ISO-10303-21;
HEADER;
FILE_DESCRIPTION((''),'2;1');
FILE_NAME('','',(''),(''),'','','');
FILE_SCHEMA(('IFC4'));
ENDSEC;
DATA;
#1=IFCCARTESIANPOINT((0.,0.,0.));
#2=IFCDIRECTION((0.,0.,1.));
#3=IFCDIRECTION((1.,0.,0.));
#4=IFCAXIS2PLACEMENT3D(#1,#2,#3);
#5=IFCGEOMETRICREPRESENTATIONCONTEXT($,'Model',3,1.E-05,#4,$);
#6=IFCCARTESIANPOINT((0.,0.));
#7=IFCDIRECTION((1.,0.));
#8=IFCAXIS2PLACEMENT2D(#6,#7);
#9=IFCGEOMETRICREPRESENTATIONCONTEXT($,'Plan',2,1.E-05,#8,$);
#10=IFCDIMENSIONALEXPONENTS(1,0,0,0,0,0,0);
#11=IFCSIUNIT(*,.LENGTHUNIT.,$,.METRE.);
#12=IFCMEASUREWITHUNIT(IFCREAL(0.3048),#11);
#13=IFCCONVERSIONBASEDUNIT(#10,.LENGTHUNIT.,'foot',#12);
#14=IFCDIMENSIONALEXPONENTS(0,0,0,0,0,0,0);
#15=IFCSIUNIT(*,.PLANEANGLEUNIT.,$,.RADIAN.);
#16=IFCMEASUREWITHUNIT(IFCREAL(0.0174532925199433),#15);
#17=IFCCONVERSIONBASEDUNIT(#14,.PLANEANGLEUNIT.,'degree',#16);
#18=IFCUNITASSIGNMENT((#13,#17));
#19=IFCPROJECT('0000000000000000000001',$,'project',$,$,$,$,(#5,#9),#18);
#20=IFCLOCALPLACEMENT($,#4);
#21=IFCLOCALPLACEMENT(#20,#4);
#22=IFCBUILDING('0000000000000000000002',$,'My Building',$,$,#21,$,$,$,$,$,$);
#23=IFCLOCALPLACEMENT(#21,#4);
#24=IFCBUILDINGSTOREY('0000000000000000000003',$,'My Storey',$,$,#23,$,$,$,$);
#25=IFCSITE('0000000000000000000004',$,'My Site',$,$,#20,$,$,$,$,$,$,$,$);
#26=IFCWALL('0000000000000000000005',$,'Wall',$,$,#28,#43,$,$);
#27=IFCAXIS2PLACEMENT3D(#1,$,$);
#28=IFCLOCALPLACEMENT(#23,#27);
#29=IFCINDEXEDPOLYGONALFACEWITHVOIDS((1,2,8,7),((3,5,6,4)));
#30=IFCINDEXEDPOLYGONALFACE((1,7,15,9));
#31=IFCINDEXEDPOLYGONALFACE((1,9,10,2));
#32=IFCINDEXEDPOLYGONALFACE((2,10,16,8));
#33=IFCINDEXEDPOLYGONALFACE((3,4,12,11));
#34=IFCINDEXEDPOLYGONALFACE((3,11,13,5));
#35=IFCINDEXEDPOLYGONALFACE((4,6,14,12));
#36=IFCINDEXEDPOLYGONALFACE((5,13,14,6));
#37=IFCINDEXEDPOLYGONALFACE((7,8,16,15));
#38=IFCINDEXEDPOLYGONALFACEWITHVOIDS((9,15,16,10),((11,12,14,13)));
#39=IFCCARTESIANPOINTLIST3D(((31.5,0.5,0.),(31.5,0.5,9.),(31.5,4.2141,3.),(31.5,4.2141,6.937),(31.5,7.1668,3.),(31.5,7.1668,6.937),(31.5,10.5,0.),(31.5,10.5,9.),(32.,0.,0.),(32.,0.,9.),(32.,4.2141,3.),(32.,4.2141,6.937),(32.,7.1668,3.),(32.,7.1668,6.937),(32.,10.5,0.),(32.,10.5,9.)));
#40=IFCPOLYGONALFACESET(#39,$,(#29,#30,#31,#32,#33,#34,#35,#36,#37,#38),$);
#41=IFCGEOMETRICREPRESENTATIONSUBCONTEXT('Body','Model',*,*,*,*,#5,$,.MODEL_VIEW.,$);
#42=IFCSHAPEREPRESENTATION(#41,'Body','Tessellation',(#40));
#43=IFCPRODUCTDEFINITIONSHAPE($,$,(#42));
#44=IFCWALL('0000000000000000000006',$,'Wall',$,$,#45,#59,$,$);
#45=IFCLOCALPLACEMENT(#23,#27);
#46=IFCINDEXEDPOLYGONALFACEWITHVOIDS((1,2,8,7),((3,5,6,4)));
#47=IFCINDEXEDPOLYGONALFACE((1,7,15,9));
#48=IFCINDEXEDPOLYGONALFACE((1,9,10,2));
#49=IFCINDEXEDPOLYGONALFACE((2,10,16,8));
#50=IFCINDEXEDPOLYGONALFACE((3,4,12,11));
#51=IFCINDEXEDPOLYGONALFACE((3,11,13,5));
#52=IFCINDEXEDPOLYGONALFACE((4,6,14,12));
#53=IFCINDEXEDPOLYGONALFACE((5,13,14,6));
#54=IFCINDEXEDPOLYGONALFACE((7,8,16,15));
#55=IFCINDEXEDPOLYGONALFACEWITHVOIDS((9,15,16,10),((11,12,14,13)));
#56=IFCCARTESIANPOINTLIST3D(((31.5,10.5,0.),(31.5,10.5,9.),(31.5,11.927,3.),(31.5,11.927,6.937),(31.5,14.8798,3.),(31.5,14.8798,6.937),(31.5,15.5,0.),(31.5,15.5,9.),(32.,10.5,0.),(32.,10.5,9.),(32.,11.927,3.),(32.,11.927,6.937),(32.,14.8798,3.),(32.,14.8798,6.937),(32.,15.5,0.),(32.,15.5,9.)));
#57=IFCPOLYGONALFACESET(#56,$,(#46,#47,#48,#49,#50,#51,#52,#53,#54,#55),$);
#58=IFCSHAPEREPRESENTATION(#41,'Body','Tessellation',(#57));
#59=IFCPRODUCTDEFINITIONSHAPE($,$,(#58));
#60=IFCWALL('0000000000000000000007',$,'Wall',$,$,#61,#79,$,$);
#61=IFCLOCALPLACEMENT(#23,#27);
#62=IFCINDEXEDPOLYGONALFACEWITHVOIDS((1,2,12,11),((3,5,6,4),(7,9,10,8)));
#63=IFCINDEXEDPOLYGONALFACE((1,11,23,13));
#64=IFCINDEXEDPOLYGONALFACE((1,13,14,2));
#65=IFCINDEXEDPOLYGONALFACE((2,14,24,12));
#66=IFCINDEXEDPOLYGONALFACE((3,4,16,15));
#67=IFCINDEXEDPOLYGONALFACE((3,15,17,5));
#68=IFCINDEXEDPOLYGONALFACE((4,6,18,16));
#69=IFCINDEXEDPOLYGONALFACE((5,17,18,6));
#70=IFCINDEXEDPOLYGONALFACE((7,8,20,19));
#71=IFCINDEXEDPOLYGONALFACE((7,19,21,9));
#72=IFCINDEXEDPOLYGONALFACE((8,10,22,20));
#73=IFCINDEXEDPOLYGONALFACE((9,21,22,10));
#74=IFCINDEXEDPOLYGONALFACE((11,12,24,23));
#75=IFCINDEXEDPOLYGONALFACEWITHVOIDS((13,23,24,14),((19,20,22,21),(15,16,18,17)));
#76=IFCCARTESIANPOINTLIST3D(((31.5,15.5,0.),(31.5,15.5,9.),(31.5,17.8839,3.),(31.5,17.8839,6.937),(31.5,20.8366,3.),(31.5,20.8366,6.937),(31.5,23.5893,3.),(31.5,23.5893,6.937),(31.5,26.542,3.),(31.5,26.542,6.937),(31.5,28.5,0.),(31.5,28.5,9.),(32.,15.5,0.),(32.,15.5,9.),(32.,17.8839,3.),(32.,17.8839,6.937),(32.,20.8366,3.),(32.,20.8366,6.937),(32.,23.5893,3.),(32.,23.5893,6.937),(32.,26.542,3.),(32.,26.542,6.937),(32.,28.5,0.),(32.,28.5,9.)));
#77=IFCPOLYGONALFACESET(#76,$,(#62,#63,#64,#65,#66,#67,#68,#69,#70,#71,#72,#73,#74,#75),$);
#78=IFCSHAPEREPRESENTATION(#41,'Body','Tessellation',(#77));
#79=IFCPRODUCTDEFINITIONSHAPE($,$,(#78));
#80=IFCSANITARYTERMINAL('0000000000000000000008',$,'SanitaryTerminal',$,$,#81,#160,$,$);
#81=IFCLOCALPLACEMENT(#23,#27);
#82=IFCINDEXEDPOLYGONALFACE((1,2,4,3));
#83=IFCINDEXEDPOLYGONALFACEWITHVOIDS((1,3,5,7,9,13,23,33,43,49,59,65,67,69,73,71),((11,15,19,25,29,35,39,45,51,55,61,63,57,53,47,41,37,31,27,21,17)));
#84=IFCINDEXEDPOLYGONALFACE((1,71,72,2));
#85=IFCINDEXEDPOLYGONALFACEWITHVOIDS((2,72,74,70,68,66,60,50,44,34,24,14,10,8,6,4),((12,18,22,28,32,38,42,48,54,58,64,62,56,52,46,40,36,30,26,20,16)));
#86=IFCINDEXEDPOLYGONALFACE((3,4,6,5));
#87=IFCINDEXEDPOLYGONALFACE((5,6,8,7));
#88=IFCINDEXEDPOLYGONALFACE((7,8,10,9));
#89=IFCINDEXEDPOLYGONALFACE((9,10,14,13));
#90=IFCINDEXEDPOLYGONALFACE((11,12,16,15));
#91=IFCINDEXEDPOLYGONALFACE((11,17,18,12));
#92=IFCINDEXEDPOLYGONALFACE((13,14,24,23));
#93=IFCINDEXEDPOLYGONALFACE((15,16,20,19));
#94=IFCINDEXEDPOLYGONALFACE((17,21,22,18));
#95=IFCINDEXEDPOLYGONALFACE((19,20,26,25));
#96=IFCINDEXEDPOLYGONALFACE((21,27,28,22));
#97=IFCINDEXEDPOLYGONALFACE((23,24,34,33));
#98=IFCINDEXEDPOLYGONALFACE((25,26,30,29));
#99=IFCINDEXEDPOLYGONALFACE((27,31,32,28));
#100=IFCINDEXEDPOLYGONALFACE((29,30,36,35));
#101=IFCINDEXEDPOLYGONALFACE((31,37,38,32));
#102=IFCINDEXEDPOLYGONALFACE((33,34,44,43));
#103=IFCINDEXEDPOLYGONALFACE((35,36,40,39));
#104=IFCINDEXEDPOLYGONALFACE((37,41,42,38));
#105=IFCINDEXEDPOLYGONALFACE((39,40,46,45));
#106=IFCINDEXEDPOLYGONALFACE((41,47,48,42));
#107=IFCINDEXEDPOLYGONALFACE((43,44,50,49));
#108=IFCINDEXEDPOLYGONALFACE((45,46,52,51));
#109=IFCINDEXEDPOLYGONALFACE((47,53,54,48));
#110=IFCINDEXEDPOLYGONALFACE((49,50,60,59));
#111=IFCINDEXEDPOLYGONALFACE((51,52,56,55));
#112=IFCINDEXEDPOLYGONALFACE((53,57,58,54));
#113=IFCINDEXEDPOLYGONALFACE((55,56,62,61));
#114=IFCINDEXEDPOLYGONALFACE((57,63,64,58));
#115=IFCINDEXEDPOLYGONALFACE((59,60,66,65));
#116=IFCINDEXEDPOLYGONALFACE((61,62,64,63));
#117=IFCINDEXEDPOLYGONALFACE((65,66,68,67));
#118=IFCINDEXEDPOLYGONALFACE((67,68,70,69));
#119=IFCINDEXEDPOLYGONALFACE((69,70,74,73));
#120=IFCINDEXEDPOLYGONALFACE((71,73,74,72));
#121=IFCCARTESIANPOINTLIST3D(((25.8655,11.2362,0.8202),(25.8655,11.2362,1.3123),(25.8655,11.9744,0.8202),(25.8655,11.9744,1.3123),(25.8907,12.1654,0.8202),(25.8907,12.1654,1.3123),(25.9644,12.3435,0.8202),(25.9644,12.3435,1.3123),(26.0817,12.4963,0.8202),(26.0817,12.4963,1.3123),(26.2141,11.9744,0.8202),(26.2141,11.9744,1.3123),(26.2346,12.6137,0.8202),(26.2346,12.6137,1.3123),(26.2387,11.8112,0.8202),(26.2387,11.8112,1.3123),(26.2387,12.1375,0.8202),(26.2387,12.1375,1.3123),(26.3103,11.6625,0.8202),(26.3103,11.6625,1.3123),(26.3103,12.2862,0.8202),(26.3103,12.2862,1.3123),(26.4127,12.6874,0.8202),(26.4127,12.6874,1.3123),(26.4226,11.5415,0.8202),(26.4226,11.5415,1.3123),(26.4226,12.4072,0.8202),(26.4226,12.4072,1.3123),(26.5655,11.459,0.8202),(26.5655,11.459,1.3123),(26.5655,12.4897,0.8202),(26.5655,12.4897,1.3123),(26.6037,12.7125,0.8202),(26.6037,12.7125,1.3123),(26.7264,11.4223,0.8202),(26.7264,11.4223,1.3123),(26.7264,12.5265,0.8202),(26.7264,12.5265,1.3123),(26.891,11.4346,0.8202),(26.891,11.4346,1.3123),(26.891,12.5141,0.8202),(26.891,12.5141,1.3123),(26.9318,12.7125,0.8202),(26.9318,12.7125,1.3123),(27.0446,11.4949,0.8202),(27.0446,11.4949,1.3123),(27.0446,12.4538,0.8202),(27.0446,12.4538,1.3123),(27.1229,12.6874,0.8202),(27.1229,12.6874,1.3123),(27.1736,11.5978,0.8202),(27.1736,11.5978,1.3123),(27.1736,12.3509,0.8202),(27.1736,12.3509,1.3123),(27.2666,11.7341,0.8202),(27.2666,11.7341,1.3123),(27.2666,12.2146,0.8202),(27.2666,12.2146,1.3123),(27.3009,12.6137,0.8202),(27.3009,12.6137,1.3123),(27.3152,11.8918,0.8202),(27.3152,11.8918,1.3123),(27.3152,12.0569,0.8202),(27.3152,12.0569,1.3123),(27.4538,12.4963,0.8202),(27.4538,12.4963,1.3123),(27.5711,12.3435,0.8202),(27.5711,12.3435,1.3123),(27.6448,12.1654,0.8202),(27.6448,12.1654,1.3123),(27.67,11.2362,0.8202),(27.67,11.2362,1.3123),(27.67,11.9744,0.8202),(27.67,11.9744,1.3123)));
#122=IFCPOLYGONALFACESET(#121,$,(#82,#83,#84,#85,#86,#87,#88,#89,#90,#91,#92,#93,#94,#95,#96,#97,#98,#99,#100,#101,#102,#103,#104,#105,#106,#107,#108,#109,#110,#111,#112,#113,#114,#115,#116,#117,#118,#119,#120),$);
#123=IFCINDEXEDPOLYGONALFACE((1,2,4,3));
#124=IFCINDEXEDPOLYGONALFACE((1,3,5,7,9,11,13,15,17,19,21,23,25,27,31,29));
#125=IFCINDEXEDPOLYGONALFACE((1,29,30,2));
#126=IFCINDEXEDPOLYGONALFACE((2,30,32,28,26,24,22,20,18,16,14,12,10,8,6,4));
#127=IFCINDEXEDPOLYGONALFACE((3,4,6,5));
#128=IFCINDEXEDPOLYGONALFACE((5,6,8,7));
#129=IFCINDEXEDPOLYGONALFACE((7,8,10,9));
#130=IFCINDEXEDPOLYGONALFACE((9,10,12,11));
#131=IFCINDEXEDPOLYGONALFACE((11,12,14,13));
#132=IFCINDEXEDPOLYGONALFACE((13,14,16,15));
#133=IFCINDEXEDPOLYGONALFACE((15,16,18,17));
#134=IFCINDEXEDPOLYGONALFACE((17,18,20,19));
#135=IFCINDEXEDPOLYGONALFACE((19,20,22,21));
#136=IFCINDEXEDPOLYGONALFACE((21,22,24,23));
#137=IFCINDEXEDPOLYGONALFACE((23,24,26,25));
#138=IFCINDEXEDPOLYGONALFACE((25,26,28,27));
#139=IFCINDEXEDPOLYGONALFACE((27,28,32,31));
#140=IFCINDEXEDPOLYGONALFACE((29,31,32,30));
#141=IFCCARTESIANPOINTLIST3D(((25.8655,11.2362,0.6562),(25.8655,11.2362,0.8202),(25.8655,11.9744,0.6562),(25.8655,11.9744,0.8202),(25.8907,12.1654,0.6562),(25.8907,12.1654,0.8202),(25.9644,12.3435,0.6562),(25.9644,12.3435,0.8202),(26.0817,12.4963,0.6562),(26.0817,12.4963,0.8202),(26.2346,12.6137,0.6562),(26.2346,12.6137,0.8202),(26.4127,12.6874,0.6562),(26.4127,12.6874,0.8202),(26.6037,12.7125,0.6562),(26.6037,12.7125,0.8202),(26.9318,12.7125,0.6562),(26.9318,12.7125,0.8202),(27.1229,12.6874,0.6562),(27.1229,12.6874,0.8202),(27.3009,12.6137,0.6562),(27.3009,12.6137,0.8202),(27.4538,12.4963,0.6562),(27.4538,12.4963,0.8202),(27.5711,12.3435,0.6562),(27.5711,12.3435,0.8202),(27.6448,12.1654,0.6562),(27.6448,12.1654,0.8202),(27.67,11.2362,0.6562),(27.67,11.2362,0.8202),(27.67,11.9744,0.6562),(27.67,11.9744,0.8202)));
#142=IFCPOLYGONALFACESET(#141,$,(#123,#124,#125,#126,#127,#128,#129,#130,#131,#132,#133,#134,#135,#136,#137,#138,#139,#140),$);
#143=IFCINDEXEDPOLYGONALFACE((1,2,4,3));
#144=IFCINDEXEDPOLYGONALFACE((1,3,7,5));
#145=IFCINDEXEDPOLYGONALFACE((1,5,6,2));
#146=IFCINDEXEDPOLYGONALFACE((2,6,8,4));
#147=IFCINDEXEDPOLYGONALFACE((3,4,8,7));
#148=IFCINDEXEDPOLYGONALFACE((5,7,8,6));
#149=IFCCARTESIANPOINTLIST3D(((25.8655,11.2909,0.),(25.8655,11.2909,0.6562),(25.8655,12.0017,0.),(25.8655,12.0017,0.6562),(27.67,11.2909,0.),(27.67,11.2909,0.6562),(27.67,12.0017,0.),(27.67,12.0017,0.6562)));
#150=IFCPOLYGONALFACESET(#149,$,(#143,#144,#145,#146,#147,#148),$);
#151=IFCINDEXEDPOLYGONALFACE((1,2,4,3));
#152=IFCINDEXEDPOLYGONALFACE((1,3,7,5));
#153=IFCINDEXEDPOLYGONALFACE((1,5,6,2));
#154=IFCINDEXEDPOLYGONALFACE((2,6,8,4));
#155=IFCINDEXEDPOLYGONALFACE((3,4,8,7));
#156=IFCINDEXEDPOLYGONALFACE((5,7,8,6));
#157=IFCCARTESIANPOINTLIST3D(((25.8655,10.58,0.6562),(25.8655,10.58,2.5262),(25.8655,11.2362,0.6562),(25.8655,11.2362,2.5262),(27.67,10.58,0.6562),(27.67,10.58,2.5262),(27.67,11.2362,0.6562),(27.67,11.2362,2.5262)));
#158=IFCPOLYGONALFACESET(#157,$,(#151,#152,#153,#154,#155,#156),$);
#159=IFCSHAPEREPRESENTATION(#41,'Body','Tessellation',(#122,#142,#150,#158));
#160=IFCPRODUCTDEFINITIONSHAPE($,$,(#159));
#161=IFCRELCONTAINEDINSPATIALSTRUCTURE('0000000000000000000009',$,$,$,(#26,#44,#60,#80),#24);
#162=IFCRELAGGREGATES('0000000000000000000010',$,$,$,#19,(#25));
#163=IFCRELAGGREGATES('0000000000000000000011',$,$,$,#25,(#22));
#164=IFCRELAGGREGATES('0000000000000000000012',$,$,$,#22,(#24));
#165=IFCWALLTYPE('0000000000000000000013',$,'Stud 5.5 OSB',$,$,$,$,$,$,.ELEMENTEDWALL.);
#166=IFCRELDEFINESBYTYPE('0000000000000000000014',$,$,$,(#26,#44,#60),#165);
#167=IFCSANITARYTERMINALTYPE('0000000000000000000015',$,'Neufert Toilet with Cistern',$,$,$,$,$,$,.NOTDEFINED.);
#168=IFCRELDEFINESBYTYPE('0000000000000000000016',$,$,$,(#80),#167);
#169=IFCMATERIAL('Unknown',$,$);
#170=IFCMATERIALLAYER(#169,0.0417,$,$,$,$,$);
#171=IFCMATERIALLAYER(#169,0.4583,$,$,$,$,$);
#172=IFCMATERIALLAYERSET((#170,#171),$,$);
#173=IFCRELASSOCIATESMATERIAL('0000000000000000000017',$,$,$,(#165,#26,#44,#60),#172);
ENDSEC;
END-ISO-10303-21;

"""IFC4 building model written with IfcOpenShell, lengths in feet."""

from ifc_helpers import new_model, entity, si_unit, converted_unit, frame, frame_2d, origin_with_axes, origin_2d_with_axis, place, context, subcontext, project, spatial, line, arc, indexed_curve, circle_curve, outline, extrude, clip, halfspace, shape, source, transform, mapped, material, layer, layer_set, layer_usage, type_object, type_shapes, element, save


model = new_model("IFC4")

# Units and contexts
model_context = context("Model", 3, precision=1e-05, world=origin_with_axes())
plan_context = context("Plan", 2, precision=1e-05, world=origin_2d_with_axis())
body_context_1 = subcontext(model_context, "Body", "Model", "MODEL_VIEW")
body_context_2 = subcontext(plan_context, "Body", "Plan", "PLAN_VIEW")
ifc_project = project(units=[converted_unit("LENGTHUNIT", "foot", entity("IfcReal", 0.3048), si_unit("LENGTHUNIT", "METRE"), dimensions=[1, 0, 0, 0, 0, 0, 0]), converted_unit("PLANEANGLEUNIT", "degree", entity("IfcReal", 0.0174532925199433), si_unit("PLANEANGLEUNIT", "RADIAN"), dimensions=[0, 0, 0, 0, 0, 0, 0])], contexts=[model_context, plan_context])

# Site, building, storey
site_placement = place(None, origin_with_axes())
site = spatial("IfcSite", under=ifc_project, at=site_placement, Name="My Site")
building_placement = place(site_placement, origin_with_axes())
building = spatial("IfcBuilding", under=site, at=building_placement, Name="My Building")
storey_placement = place(building_placement, origin_with_axes())
storey = spatial("IfcBuildingStorey", under=building, at=storey_placement, Name="My Storey")

# Shared definitions
ifc_material = material(Name="Unknown")

# Shared definitions
ifc_layer_1 = layer(ifc_material, 0.0417)
ifc_layer_2 = layer(ifc_material, 0.4583)
ifc_layer_set_1 = layer_set([ifc_layer_1, ifc_layer_2])
wall_type_1 = type_object("IfcWallType", Name="Stud 5.5 OSB", PredefinedType="ELEMENTEDWALL", material=ifc_layer_set_1)
shared_shape_1 = source(origin_with_axes(), body_context_1, "Body", "SweptSolid", [
    extrude(outline(indexed_curve([(0.0, 0.0), (2.9528, 0.0), (2.9528, 3.937), (0.0, 3.937)], segments=[line(1, 2, 3, 4, 1)])), frame((0.0, -1.9685, 0.0), z_axis=(0.0, -1.0, 0.0), x_axis=(1.0, 0.0, 0.0)), (0.0, 0.0, -1.0), 3.937),
])

# Walls, openings
ifc_layer_usage_1 = layer_usage(ifc_layer_set_1, "AXIS2", "POSITIVE", 0.0)
wall_1_placement = place(storey_placement, frame((32.0, 0.0, 0.0), z_axis=(0.0, 0.0, 1.0), x_axis=(0.0, 1.0, 0.0)))
wall_1 = element("IfcWall", 1, at=wall_1_placement, inside=storey, type_object=wall_type_1, material=ifc_layer_usage_1, Name="Wall", context=body_context_1, shape_type="Clipping", body=[
    clip(extrude(outline(indexed_curve([(0.0, 0.0), (0.0, 0.5), (10.5, 0.5), (10.5, 0.0), (0.0, 0.0)], self_intersect=False)), origin_with_axes(), (0.0, 0.0, 1.0), 9.0), halfspace(frame((0.0, 0.0, 0.0), z_axis=(-0.707107, 0.707106, 0.0), x_axis=(0.707107, 0.707107, 0.0)), False)),
])
opening_1_placement = place(wall_1_placement, frame((4.2141, 0.0, 3.0), z_axis=(0.0, 0.0, 1.0), x_axis=(1.0, 0.0, 0.0)))
element("IfcOpeningElement", 2, at=opening_1_placement, cuts=wall_1, PredefinedType="OPENING", context=body_context_1, shape_type="MappedRepresentation", body=[
    mapped(shared_shape_1, transform((0.0, 0.0, 0.0), x_axis=(1.0, 0.0, 0.0), y_axis=(0.0, 1.0, 0.0), z_axis=(0.0, 0.0, 1.0), scale=1.0)),
])
ifc_layer_usage_2 = layer_usage(ifc_layer_set_1, "AXIS2", "POSITIVE", 0.0)
wall_2_placement = place(storey_placement, frame((32.0, 10.5, 0.0), z_axis=(0.0, 0.0, 1.0), x_axis=(0.0, 1.0, 0.0)))
wall_2 = element("IfcWall", 3, at=wall_2_placement, inside=storey, type_object=wall_type_1, material=ifc_layer_usage_2, Name="Wall", context=body_context_1, shape_type="SweptSolid", body=[
    extrude(outline(indexed_curve([(0.0, 0.0), (0.0, 0.5), (5.0, 0.5), (5.0, 0.0), (0.0, 0.0)], self_intersect=False)), origin_with_axes(), (0.0, 0.0, 1.0), 9.0),
])
opening_2_placement = place(wall_2_placement, frame((1.427, 0.0, 3.0), z_axis=(0.0, 0.0, 1.0), x_axis=(1.0, 0.0, 0.0)))
element("IfcOpeningElement", 4, at=opening_2_placement, cuts=wall_2, PredefinedType="OPENING", context=body_context_1, shape_type="MappedRepresentation", body=[
    mapped(shared_shape_1, transform((0.0, 0.0, 0.0), x_axis=(1.0, 0.0, 0.0), y_axis=(0.0, 1.0, 0.0), z_axis=(0.0, 0.0, 1.0), scale=1.0)),
])

# Wall, openings
ifc_layer_usage_3 = layer_usage(ifc_layer_set_1, "AXIS2", "POSITIVE", 0.0)
wall_3_placement = place(storey_placement, frame((32.0, 15.5, 0.0), z_axis=(0.0, 0.0, 1.0), x_axis=(0.0, 1.0, 0.0)))
wall_3 = element("IfcWall", 5, at=wall_3_placement, inside=storey, type_object=wall_type_1, material=ifc_layer_usage_3, Name="Wall", context=body_context_1, shape_type="SweptSolid", body=[
    extrude(outline(indexed_curve([(0.0, 0.0), (0.0, 0.5), (13.0, 0.5), (13.0, 0.0), (0.0, 0.0)], self_intersect=False)), origin_with_axes(), (0.0, 0.0, 1.0), 9.0),
])
opening_3_placement = place(wall_3_placement, frame((2.3839, 0.0, 3.0), z_axis=(0.0, 0.0, 1.0), x_axis=(1.0, 0.0, 0.0)))
element("IfcOpeningElement", 6, at=opening_3_placement, cuts=wall_3, PredefinedType="OPENING", context=body_context_1, shape_type="MappedRepresentation", body=[
    mapped(shared_shape_1, transform((0.0, 0.0, 0.0), x_axis=(1.0, 0.0, 0.0), y_axis=(0.0, 1.0, 0.0), z_axis=(0.0, 0.0, 1.0), scale=1.0)),
])
opening_4_placement = place(wall_3_placement, frame((8.0893, 0.0, 3.0), z_axis=(0.0, 0.0, 1.0), x_axis=(1.0, 0.0, 0.0)))
element("IfcOpeningElement", 7, at=opening_4_placement, cuts=wall_3, PredefinedType="OPENING", context=body_context_1, shape_type="MappedRepresentation", body=[
    mapped(shared_shape_1, transform((0.0, 0.0, 0.0), x_axis=(1.0, 0.0, 0.0), y_axis=(0.0, 1.0, 0.0), z_axis=(0.0, 0.0, 1.0), scale=1.0)),
])

# Sanitary terminal
sanitary_terminal_type_1 = type_object("IfcSanitaryTerminalType", Name="Neufert Toilet with Cistern", PredefinedType="NOTDEFINED")
shared_shape_2 = source(origin_with_axes(), body_context_1, "Body", "SweptSolid", [
    extrude(outline(indexed_curve([(-0.9022, -0.6562), (0.9022, -0.6562), (0.9022, -1.3944), (0.686, -1.9163), (0.164, -2.1325), (-0.164, -2.1325), (-0.686, -1.9163), (-0.9022, -1.3944)], segments=[line(1, 2), line(2, 3), arc(3, 4, 5), line(5, 6), arc(6, 7, 8), line(8, 1)]), holes=[circle_curve(frame_2d((0.0, -1.3944)), 0.5536)]), frame((0.0, 0.0, 0.8202), z_axis=(0.0, 0.0, 1.0), x_axis=(1.0, 0.0, 0.0)), (0.0, 0.0, 1.0), 0.4921),
    extrude(outline(indexed_curve([(-0.9022, -0.6562), (0.9022, -0.6562), (0.9022, -1.3944), (0.686, -1.9163), (0.164, -2.1325), (-0.164, -2.1325), (-0.686, -1.9163), (-0.9022, -1.3944)], segments=[line(1, 2), line(2, 3), arc(3, 4, 5), line(5, 6), arc(6, 7, 8), line(8, 1)])), frame((0.0, 0.0, 0.6562), z_axis=(0.0, 0.0, 1.0), x_axis=(1.0, 0.0, 0.0)), (0.0, 0.0, 1.0), 0.164),
    extrude(outline(indexed_curve([(-0.9022, -0.7108), (0.9022, -0.7108), (0.9022, -1.4217), (-0.9022, -1.4217)], segments=[line(1, 2, 3, 4, 1)])), origin_with_axes(), (0.0, 0.0, 1.0), 0.6562),
    extrude(outline(indexed_curve([(-0.9022, 0.0), (0.9022, 0.0), (0.9022, -0.6562), (-0.9022, -0.6562)], segments=[line(1, 2, 3, 4, 1)])), frame((0.0, 0.0, 0.6562), z_axis=(0.0, 0.0, 1.0), x_axis=(1.0, 0.0, 0.0)), (0.0, 0.0, 1.0), 1.8701),
])
shared_shape_3 = source(origin_with_axes(), body_context_2, "Body", "Curve2D", [
    entity("IfcIndexedPolyCurve", entity("IfcCartesianPointList2D", [[-0.9022, 0.0], [0.9022, 0.0], [0.9022, -0.6562], [-0.9022, -0.6562]]), [entity("IfcLineIndex", [1, 2, 3, 4, 1])]),
    entity("IfcIndexedPolyCurve", entity("IfcCartesianPointList2D", [[0.5413, -0.6562], [0.6316, -1.0991]])),
    entity("IfcTrimmedCurve", entity("IfcEllipse", entity("IfcAxis2Placement2D", entity("IfcCartesianPoint", [0.0, -1.0991]), entity("IfcDirection", [1.0, 0.0])), 0.6316, 1.0335), [entity("IfcCartesianPoint", [-0.6316, -1.0991])], [entity("IfcCartesianPoint", [0.6316, -1.0991])], True, "CARTESIAN"),
    entity("IfcIndexedPolyCurve", entity("IfcCartesianPointList2D", [[-0.5413, -0.6562], [-0.6316, -1.0991]])),
    entity("IfcEllipse", entity("IfcAxis2Placement2D", entity("IfcCartesianPoint", [0.0, -1.4829]), entity("IfcDirection", [1.0, 0.0])), 0.4306, 0.5167),
    entity("IfcIndexedPolyCurve", entity("IfcCartesianPointList2D", [[-0.1128, -1.4829], [-0.1128, -1.4091], [0.1128, -1.4091], [0.1128, -1.4829]])),
    entity("IfcTrimmedCurve", entity("IfcEllipse", entity("IfcAxis2Placement2D", entity("IfcCartesianPoint", [0.0, -1.4829]), entity("IfcDirection", [1.0, 0.0])), 0.1128, 0.0738), [entity("IfcCartesianPoint", [-0.1128, -1.4829])], [entity("IfcCartesianPoint", [0.1128, -1.4829])], True, "CARTESIAN"),
])
type_shapes(sanitary_terminal_type_1, [shared_shape_2, shared_shape_3])
sanitary_terminal_1_placement = place(storey_placement, frame((26.7678, 10.58, 0.0), z_axis=(0.0, 0.0, 1.0), x_axis=(-1.0, 0.0, 0.0)))
element("IfcSanitaryTerminal", 8, at=sanitary_terminal_1_placement, inside=storey, type_object=sanitary_terminal_type_1, Name="SanitaryTerminal", shapes=[
    shape(body_context_1, "Body", "MappedRepresentation", [mapped(shared_shape_2, transform((0.0, 0.0, 0.0), x_axis=(1.0, 0.0, 0.0), y_axis=(0.0, 1.0, 0.0), z_axis=(0.0, 0.0, 1.0), scale=1.0))]),
    shape(body_context_2, "Body", "MappedRepresentation", [mapped(shared_shape_3, transform((0.0, 0.0, 0.0), x_axis=(1.0, 0.0, 0.0), y_axis=(0.0, 1.0, 0.0), z_axis=(0.0, 0.0, 1.0), scale=1.0))]),
])

save(model, "model.ifc")
